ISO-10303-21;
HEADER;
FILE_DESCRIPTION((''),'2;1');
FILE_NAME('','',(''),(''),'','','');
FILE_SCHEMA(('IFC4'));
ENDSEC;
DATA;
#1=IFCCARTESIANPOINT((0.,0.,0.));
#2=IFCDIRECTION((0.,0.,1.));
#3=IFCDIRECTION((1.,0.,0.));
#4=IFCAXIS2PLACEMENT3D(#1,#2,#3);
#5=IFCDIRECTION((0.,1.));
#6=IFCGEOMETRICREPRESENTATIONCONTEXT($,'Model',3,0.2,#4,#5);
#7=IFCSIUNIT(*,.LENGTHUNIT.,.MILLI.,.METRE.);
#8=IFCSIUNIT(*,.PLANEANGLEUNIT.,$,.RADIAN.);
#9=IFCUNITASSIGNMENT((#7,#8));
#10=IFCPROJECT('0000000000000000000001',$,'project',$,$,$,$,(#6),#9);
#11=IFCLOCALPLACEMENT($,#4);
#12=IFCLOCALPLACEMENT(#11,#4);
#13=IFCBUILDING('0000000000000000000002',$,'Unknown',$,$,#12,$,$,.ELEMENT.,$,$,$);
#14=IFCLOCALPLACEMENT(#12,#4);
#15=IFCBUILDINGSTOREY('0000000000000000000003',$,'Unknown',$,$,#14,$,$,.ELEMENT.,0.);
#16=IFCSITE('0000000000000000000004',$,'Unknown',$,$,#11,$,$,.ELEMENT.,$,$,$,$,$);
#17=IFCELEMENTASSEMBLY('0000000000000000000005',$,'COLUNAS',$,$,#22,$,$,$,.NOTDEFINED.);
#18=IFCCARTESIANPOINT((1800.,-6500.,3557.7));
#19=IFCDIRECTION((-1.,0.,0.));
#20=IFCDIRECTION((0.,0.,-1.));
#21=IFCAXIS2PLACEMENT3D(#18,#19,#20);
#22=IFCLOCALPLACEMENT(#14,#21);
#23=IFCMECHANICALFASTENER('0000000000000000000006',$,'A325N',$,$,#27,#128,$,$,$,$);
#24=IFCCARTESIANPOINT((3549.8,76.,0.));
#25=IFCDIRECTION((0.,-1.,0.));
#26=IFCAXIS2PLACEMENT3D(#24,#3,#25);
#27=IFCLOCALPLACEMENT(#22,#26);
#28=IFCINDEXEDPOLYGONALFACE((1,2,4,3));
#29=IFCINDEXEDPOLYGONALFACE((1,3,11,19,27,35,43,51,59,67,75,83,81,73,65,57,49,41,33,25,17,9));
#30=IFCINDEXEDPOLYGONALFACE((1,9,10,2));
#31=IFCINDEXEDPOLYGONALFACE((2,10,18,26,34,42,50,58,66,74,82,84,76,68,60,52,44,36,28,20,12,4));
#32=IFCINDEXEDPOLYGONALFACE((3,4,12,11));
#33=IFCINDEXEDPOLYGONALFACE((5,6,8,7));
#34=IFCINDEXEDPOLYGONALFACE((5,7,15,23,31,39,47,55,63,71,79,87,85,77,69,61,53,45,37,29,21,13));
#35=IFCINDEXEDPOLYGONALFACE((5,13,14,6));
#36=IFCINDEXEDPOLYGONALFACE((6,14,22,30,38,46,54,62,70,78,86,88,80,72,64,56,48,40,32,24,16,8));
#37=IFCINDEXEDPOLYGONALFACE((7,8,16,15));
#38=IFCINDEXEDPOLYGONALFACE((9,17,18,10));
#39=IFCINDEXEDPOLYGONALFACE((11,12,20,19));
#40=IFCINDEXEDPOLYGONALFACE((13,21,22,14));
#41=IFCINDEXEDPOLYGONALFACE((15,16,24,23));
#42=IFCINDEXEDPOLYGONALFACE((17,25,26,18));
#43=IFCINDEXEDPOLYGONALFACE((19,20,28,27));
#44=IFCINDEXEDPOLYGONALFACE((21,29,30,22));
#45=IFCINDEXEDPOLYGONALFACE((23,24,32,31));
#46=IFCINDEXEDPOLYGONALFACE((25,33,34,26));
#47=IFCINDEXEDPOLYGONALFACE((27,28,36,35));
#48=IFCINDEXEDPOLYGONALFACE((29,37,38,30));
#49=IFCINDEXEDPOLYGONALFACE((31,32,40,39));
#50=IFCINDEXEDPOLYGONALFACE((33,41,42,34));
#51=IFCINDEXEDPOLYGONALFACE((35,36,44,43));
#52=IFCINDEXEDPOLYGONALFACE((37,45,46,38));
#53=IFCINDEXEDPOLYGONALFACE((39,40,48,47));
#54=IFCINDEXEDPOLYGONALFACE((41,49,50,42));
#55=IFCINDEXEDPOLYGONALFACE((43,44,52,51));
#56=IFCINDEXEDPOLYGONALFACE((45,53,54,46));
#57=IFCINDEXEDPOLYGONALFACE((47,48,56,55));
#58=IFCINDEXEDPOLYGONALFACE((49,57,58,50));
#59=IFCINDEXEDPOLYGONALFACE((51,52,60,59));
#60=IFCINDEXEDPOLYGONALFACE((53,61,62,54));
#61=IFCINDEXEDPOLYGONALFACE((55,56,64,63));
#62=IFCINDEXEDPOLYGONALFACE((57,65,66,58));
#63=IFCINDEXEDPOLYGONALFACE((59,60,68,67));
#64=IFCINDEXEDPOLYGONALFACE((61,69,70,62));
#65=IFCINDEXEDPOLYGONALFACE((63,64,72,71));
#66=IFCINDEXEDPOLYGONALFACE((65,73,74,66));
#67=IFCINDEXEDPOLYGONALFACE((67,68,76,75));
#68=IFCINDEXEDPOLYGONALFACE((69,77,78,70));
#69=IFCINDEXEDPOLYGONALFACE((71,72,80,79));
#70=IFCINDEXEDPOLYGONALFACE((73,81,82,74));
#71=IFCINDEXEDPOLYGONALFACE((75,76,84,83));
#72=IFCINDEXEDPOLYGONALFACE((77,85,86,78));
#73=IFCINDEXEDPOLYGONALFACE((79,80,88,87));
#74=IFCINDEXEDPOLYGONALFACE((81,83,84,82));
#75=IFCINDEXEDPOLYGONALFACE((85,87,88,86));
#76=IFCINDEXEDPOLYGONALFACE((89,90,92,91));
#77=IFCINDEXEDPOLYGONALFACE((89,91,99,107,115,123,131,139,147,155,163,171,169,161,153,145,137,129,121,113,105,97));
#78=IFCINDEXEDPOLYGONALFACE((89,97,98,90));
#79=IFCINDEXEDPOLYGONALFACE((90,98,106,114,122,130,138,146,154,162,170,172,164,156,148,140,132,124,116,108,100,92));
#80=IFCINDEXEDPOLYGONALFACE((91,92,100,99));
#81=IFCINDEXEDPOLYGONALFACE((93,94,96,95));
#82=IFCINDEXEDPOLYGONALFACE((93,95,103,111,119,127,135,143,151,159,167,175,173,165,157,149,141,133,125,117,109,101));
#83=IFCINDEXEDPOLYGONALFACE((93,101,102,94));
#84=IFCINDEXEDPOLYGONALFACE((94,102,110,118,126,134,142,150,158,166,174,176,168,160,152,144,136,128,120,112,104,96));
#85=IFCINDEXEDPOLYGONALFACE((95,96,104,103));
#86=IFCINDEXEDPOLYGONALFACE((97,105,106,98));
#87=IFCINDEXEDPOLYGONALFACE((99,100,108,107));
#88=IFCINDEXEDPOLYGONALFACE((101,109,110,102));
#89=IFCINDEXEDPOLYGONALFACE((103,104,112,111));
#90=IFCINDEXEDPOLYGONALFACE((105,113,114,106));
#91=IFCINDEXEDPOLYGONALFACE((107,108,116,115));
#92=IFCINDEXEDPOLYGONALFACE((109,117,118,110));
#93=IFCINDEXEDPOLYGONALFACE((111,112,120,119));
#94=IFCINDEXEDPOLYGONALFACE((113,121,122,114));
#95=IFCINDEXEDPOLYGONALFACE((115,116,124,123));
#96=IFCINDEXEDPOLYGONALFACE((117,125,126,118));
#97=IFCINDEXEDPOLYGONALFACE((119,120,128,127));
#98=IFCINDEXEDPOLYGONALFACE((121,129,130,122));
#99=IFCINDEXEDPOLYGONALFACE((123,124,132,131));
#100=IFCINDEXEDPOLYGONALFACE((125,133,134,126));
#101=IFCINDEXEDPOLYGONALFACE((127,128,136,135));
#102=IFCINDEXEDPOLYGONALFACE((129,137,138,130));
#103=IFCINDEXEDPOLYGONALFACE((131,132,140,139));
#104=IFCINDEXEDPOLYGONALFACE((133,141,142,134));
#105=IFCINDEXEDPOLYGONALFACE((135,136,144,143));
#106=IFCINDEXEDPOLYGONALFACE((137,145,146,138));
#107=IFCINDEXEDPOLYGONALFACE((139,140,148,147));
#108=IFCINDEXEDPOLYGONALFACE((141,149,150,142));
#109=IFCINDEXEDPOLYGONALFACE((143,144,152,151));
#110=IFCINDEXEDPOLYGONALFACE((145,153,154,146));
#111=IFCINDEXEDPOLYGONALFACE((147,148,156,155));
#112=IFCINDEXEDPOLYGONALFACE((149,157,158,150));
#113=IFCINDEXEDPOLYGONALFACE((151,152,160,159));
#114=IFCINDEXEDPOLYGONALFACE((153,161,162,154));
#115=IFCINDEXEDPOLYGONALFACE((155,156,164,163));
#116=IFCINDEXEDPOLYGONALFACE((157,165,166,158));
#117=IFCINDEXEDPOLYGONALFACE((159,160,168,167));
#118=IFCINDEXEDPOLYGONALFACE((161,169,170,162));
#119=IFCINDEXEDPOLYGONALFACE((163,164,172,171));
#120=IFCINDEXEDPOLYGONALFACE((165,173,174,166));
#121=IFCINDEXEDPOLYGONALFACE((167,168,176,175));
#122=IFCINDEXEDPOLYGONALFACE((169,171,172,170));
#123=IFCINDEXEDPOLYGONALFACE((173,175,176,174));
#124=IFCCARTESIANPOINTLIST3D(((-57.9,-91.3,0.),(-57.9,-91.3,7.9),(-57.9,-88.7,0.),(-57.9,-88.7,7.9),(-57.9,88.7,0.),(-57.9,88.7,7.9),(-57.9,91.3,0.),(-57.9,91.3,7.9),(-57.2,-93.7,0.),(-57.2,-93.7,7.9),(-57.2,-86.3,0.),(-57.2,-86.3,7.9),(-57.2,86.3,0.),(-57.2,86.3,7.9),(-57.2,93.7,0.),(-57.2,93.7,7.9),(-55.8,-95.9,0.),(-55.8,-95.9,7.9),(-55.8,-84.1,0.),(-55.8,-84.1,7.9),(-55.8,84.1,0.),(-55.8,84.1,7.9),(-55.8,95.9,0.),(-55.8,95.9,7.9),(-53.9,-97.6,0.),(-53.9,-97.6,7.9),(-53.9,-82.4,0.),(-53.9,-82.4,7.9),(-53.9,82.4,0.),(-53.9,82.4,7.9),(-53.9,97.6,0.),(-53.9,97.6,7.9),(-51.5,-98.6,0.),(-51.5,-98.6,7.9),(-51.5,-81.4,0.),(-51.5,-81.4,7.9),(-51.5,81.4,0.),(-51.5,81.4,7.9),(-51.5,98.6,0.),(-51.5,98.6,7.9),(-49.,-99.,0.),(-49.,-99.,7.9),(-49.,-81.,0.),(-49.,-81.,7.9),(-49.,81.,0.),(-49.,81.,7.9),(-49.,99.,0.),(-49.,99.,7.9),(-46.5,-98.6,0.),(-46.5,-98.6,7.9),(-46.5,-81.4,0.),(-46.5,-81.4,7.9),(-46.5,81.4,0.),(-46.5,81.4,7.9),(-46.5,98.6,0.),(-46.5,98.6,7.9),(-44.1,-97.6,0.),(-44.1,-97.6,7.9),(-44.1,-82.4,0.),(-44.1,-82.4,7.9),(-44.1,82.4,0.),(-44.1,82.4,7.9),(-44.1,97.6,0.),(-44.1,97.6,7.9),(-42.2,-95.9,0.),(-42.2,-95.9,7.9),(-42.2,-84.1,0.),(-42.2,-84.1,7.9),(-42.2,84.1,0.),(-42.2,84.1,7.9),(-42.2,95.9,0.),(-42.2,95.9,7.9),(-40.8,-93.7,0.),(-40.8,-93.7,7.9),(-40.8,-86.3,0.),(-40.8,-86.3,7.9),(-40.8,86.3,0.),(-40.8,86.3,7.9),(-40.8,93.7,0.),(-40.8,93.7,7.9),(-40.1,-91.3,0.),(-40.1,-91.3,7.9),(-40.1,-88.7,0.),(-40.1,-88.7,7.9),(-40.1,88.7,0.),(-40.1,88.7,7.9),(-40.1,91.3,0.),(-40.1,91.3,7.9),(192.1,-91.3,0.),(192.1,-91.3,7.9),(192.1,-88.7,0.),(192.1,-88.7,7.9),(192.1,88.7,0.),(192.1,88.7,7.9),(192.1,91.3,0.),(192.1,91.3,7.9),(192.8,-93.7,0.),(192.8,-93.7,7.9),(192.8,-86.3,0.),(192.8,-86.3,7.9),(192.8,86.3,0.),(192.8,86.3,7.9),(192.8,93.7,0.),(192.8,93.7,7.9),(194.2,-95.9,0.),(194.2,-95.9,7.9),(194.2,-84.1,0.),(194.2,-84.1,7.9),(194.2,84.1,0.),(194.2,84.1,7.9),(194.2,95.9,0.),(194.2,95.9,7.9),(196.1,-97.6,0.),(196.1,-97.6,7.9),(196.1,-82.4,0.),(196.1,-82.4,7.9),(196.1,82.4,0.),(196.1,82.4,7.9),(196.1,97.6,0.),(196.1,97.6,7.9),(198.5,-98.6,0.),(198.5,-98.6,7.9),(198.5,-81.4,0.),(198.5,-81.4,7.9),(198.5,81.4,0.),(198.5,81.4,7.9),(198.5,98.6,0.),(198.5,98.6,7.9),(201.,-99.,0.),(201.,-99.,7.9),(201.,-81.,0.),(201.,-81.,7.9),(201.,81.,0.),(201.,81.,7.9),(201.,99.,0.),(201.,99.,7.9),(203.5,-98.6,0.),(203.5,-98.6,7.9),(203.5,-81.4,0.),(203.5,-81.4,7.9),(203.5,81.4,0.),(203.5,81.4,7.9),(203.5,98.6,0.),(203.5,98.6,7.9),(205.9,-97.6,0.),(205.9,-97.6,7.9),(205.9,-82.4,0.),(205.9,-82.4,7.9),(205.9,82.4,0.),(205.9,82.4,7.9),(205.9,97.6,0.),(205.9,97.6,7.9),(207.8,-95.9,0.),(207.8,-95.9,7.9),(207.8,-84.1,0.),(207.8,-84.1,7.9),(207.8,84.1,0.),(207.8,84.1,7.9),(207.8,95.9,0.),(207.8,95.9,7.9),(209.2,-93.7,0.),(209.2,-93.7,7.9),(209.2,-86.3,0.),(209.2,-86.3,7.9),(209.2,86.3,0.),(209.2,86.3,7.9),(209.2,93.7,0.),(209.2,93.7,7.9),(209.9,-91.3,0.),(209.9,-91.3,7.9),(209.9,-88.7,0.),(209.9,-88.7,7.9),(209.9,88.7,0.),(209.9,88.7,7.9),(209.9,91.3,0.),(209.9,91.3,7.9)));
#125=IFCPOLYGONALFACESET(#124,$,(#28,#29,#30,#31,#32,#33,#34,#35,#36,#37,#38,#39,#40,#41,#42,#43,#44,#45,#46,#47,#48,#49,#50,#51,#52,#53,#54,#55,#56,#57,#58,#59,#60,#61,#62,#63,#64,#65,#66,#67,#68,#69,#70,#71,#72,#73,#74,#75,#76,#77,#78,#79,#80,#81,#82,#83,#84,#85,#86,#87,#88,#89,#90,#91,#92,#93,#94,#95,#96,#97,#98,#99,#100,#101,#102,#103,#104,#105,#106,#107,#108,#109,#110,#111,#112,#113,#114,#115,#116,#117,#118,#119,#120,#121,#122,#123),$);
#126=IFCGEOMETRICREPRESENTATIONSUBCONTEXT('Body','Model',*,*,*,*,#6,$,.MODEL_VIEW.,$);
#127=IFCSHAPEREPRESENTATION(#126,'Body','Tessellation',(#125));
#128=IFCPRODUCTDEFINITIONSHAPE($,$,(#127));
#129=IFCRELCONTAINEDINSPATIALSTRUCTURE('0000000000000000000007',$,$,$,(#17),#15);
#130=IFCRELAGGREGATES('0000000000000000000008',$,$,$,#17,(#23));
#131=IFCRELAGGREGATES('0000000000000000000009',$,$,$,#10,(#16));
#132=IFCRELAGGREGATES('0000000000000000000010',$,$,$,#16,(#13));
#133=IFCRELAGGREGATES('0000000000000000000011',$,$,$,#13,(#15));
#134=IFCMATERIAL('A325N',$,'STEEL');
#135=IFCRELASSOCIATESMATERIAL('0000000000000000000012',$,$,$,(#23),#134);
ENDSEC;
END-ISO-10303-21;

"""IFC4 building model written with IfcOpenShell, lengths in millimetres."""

from ifc_helpers import new_model, si_unit, direction, frame, origin_with_axes, place, context, subcontext, project, spatial, arc, indexed_curve, outline, extrude, source, transform, mapped, material, element, aggregate, save


model = new_model("IFC4")

# Units and contexts
model_context = context("Model", 3, precision=0.2, world=origin_with_axes(), true_north=direction((0.0, 1.0)))
body_context = subcontext(model_context, "Body", "Model", "MODEL_VIEW")
ifc_project = project(units=[si_unit("LENGTHUNIT", "METRE", prefix="MILLI"), si_unit("PLANEANGLEUNIT", "RADIAN")], contexts=[model_context])

# Site, building, storey
site_placement = place(None, origin_with_axes())
site = spatial("IfcSite", under=ifc_project, at=site_placement, Name="Unknown", CompositionType="ELEMENT")
building_placement = place(site_placement, origin_with_axes())
building = spatial("IfcBuilding", under=site, at=building_placement, Name="Unknown", CompositionType="ELEMENT")
storey_placement = place(building_placement, origin_with_axes())
storey = spatial("IfcBuildingStorey", under=building, at=storey_placement, Name="Unknown", CompositionType="ELEMENT", Elevation=0.0)

# Element assembly
assembly_1_placement = place(storey_placement, frame((1800.0, -6500.0, 3557.7), z_axis=(-1.0, 0.0, 0.0), x_axis=(0.0, 0.0, -1.0)))
assembly_1 = element("IfcElementAssembly", 1, at=assembly_1_placement, inside=storey, Name="COLUNAS", PredefinedType="NOTDEFINED")

# Mechanical fastener
ifc_material_1 = material(Name="A325N", Category="STEEL")
shared_shape = source(origin_with_axes(), body_context, "Body", "SweptSolid", [
    extrude(outline(indexed_curve([(9.0, 0.0), (0.0, 9.0), (-9.0, 0.0), (0.0, -9.0)], segments=[arc(1, 2, 3), arc(3, 4, 1)])), frame((0.0, 0.0, 7.9), z_axis=(0.0, 0.0, -1.0), x_axis=(0.0, 1.0, 0.0)), (0.0, 0.0, 1.0), 7.9),
])
mechanical_fastener_1_placement = place(assembly_1_placement, frame((3549.8, 76.0, 0.0), z_axis=(1.0, 0.0, 0.0), x_axis=(0.0, -1.0, 0.0)))
mechanical_fastener_1 = element("IfcMechanicalFastener", 2, at=mechanical_fastener_1_placement, material=ifc_material_1, Name="A325N", context=body_context, shape_type="MappedRepresentation", body=[
    mapped(shared_shape, transform((-49.0, -90.0, 0.0))),
    mapped(shared_shape, transform((-49.0, 90.0, 0.0))),
    mapped(shared_shape, transform((201.0, -90.0, 0.0))),
    mapped(shared_shape, transform((201.0, 90.0, 0.0))),
])
aggregate(assembly_1, [mechanical_fastener_1])

save(model, "model.ifc")
